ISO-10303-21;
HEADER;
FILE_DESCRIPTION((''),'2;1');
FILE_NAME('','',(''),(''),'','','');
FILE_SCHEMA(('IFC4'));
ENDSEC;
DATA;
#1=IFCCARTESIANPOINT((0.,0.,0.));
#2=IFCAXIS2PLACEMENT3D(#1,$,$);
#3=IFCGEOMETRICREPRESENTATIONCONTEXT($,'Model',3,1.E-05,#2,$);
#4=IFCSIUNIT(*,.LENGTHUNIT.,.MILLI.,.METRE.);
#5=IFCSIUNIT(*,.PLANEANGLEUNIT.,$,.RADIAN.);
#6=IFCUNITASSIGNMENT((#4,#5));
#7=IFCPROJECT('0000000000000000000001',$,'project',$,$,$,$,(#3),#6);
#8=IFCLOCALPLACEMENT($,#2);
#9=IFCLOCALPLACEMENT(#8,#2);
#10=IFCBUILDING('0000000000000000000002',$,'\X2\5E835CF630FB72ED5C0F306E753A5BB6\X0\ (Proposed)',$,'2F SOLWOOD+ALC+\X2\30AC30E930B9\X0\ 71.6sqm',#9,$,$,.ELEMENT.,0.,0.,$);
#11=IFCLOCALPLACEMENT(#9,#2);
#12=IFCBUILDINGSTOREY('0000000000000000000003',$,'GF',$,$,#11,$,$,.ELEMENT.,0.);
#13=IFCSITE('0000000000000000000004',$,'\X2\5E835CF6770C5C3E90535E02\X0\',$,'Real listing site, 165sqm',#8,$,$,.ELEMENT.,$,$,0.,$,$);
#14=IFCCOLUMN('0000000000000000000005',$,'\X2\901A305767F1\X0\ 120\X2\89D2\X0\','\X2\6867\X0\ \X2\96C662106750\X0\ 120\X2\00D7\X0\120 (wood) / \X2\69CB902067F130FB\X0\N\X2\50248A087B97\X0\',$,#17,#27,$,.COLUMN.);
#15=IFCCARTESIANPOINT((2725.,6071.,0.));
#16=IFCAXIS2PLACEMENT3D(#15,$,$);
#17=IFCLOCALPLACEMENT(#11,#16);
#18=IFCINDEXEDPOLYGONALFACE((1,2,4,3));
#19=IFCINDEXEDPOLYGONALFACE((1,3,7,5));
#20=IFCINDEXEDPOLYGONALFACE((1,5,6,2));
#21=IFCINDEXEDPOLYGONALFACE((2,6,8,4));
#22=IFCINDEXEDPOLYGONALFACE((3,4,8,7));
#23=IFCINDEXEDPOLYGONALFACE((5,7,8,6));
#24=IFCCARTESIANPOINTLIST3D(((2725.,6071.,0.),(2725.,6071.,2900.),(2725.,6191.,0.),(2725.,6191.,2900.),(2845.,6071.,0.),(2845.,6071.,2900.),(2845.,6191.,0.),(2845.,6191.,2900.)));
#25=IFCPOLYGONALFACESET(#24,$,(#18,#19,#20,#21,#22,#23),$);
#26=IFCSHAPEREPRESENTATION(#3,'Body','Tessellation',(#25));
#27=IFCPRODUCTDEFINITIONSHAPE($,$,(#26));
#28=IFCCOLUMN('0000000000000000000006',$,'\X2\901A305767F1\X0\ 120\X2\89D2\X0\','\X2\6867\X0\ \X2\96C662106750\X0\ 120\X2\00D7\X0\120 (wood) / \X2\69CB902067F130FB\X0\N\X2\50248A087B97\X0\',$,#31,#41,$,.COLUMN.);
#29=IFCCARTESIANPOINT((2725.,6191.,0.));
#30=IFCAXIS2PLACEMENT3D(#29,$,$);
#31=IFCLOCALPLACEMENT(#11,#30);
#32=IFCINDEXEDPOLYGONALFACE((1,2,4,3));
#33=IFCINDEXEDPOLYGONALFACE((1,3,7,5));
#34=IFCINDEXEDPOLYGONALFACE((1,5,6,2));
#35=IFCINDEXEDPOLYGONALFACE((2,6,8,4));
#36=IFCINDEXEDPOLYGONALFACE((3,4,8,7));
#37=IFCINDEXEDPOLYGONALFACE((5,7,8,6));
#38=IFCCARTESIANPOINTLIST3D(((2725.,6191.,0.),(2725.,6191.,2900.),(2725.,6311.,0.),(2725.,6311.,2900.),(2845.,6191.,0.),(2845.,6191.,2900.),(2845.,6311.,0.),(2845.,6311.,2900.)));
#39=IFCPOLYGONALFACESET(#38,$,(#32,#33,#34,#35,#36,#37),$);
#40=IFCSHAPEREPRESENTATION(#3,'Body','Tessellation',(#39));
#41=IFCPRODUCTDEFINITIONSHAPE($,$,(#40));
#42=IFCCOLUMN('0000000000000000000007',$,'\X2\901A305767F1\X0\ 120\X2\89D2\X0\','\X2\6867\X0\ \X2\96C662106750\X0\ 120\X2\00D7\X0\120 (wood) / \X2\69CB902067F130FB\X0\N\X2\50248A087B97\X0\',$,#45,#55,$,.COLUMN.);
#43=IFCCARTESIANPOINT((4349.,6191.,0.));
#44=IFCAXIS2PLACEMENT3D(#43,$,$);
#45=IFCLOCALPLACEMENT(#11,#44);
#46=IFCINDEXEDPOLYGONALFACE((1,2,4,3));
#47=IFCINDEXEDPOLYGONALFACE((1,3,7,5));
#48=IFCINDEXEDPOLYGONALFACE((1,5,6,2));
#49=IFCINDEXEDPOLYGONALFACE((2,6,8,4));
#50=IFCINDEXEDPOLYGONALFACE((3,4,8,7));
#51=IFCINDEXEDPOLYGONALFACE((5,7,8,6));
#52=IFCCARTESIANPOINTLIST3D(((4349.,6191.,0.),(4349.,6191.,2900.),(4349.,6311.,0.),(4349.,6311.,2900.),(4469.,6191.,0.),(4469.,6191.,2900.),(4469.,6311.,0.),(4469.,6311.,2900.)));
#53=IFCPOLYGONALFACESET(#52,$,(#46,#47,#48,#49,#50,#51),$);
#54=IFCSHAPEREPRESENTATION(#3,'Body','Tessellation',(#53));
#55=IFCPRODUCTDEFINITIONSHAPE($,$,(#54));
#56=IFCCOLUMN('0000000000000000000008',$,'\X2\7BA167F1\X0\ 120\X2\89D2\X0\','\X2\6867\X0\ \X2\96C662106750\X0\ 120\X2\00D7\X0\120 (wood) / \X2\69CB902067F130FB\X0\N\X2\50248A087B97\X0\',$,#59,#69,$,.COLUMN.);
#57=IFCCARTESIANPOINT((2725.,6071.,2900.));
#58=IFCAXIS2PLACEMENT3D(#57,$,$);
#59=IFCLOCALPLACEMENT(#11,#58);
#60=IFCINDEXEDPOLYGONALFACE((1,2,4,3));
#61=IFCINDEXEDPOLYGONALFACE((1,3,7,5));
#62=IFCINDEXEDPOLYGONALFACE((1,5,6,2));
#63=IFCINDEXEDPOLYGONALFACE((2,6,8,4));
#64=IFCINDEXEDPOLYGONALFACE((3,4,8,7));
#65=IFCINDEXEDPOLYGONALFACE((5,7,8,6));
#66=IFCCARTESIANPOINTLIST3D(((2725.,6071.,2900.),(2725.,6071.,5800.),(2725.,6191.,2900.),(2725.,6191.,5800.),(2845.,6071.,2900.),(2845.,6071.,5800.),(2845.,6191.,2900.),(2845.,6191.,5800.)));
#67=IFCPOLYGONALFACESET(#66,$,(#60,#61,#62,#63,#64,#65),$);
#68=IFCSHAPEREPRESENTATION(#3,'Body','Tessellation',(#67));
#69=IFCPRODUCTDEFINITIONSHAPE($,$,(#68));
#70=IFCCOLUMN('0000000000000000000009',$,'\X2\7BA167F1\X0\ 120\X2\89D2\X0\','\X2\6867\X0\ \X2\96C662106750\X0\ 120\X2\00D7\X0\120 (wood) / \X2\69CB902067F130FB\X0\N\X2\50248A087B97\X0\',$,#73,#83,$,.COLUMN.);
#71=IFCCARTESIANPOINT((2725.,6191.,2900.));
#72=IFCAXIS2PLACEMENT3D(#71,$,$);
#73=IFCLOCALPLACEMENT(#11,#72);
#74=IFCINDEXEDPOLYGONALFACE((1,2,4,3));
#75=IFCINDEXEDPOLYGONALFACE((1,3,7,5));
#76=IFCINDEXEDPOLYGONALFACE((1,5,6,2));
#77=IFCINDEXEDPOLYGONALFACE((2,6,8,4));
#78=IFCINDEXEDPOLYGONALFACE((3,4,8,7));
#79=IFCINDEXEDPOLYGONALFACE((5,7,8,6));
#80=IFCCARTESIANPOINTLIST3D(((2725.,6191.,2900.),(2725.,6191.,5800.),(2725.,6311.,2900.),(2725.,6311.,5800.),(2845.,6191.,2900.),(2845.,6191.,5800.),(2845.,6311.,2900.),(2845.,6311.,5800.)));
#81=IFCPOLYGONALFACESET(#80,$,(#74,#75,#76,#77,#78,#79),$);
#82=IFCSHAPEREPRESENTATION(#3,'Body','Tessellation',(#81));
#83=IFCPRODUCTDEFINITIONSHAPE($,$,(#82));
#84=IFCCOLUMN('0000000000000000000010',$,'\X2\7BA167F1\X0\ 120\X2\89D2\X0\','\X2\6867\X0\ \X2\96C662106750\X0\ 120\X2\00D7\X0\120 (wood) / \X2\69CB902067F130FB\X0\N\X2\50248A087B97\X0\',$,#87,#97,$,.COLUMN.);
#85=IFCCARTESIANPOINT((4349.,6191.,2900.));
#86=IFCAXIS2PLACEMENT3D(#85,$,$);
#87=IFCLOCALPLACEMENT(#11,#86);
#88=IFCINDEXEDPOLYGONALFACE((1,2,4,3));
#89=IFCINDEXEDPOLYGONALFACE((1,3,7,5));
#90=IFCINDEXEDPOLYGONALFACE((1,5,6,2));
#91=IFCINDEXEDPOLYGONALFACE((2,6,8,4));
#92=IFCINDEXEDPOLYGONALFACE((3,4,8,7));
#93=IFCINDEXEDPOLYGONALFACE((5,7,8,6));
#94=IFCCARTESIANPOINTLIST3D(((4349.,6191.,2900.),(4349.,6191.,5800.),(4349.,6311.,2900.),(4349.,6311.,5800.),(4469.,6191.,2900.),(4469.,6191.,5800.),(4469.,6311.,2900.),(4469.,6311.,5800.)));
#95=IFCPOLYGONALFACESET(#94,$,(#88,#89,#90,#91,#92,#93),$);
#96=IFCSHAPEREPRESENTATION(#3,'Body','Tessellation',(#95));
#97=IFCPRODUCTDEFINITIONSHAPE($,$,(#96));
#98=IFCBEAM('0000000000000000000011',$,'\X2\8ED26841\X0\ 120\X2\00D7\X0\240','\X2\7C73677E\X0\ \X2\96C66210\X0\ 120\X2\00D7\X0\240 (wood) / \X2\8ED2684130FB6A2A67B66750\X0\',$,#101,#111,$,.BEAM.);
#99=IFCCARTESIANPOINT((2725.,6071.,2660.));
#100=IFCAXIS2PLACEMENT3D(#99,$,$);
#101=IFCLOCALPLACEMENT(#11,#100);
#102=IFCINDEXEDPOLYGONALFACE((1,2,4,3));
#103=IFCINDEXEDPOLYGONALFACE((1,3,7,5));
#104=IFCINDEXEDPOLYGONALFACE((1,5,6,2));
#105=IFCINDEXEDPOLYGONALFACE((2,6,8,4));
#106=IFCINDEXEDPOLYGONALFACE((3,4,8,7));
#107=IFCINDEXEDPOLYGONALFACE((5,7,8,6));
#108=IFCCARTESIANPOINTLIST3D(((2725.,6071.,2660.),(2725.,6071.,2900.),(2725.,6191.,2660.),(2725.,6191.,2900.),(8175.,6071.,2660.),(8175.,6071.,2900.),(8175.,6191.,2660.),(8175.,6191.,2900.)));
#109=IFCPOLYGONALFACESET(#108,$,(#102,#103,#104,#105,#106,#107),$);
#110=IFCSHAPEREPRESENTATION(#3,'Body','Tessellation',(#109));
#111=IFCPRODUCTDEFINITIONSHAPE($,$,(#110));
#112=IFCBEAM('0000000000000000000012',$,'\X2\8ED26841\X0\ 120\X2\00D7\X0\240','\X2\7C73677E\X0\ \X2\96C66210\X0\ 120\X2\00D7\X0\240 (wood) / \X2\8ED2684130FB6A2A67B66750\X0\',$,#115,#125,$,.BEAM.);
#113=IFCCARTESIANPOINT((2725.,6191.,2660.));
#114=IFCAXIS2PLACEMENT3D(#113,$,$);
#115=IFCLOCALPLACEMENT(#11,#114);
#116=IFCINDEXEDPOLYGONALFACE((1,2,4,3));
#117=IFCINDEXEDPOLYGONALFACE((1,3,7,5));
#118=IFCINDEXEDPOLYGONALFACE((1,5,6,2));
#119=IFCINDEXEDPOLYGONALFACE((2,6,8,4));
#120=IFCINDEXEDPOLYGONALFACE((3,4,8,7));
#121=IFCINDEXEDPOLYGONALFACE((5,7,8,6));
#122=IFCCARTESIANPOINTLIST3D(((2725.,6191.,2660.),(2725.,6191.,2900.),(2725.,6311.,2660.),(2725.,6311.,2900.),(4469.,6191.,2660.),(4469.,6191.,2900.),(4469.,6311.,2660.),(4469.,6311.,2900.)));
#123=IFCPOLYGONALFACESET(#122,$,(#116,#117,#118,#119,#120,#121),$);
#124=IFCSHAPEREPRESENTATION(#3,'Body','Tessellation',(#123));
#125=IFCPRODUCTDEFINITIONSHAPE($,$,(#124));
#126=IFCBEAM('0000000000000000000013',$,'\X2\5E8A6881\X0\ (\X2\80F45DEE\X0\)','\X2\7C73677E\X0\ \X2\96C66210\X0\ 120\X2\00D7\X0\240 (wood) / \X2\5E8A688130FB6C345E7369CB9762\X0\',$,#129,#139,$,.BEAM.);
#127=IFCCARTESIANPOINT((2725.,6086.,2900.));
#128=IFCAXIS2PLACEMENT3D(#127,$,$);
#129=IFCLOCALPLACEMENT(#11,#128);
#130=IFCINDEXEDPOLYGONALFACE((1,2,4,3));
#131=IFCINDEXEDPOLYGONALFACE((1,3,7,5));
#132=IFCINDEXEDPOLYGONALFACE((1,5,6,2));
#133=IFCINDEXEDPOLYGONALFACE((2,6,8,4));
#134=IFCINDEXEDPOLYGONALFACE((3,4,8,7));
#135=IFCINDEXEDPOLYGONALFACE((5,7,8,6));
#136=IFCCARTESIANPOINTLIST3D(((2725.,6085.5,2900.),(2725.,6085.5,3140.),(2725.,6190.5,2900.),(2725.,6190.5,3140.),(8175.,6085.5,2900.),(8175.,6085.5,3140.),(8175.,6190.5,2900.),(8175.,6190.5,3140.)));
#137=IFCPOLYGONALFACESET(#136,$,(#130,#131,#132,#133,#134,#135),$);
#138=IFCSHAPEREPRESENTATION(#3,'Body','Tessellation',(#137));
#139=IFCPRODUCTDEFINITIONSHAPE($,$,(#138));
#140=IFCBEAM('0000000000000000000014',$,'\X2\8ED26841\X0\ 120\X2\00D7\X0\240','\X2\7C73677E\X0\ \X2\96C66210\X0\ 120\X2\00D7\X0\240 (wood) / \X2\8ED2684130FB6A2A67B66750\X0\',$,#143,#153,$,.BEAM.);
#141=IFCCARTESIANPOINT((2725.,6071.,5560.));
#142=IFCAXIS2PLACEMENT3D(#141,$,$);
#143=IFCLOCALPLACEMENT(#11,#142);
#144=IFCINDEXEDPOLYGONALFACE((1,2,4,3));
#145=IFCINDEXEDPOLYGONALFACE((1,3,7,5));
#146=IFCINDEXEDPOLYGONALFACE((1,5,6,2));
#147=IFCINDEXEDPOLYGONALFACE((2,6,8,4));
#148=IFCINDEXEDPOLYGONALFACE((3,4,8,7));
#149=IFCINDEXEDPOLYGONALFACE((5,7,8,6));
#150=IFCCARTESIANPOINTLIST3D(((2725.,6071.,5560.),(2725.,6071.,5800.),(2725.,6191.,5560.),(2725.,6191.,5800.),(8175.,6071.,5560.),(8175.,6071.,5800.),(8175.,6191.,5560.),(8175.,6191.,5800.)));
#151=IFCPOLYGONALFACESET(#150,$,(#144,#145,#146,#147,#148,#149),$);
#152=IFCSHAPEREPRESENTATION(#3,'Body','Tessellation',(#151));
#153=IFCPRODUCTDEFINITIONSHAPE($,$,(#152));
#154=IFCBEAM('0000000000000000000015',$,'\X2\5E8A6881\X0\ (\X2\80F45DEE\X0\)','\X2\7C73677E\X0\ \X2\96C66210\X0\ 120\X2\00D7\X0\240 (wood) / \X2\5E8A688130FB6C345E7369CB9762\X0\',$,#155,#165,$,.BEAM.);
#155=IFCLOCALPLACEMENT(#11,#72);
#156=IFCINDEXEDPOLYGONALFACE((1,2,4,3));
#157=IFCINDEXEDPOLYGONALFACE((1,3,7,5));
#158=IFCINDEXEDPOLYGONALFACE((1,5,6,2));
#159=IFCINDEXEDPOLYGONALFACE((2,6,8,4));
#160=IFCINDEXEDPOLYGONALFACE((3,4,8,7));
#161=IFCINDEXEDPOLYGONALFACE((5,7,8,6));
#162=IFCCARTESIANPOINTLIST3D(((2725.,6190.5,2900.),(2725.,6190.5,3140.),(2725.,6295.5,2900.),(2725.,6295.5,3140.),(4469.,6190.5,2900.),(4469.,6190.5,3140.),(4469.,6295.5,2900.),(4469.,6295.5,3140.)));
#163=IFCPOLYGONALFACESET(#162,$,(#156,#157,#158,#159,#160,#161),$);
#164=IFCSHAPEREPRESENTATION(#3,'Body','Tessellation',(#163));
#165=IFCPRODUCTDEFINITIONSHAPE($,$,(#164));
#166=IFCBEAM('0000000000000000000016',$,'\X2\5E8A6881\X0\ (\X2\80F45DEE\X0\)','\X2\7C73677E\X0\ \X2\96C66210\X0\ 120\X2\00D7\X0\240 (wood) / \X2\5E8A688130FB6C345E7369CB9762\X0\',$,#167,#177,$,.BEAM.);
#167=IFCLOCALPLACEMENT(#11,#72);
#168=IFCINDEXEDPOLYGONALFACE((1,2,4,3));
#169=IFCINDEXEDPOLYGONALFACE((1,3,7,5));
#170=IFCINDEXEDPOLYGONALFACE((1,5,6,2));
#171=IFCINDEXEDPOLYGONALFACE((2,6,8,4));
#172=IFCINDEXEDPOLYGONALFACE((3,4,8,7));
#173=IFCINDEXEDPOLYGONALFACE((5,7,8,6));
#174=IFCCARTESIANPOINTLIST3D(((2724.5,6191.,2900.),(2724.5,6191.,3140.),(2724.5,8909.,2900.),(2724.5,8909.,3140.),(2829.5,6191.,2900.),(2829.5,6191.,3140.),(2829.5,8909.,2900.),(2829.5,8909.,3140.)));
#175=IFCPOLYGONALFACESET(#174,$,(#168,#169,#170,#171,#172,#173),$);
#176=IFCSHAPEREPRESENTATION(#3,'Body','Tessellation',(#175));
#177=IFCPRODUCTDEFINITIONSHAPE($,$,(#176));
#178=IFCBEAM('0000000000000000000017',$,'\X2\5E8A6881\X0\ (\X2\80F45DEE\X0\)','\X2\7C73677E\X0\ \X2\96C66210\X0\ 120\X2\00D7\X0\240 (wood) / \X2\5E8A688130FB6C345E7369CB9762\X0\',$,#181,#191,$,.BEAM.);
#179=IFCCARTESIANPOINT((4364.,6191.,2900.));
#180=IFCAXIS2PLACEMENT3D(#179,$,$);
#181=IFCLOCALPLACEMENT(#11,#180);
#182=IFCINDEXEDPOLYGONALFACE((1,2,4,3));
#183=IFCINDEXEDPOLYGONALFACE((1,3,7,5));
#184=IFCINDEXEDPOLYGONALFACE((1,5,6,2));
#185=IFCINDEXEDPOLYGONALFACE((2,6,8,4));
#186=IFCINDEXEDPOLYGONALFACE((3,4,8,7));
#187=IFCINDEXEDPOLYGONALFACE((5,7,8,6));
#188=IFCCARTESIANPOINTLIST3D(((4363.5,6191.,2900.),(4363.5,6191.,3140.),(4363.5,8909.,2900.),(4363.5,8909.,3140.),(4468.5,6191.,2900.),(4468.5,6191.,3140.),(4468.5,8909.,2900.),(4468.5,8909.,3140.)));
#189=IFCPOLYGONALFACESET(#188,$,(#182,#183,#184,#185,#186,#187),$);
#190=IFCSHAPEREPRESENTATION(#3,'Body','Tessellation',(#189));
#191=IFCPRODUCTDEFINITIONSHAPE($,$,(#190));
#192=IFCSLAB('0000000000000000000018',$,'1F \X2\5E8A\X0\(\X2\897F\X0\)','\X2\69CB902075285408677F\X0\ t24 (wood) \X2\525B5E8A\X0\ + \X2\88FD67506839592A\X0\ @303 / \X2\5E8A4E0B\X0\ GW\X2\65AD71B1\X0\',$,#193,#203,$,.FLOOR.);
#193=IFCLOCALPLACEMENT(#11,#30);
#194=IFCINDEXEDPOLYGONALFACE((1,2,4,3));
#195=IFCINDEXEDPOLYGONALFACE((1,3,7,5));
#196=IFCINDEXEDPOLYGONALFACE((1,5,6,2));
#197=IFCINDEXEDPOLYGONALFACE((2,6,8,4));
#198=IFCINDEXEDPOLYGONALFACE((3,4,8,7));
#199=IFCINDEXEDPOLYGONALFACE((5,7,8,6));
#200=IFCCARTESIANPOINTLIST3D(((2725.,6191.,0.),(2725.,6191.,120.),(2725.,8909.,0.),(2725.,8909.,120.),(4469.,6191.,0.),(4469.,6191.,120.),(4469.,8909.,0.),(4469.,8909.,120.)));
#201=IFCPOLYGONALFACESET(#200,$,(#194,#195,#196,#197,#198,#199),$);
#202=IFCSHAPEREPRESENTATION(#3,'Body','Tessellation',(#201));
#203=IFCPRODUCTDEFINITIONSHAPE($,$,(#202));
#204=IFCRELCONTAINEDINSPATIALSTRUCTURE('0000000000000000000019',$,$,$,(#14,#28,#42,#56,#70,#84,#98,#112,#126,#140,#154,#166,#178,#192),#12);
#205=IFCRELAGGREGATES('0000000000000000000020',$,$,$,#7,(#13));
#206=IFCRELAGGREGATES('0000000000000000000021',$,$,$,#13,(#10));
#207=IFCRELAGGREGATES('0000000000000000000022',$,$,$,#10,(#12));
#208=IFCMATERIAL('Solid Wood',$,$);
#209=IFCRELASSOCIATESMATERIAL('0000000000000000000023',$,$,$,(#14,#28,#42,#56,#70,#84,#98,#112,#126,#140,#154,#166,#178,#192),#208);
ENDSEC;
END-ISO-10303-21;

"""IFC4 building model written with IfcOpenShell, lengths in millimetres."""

from ifc_helpers import new_model, si_unit, frame, frame_2d, origin, place, context, project, spatial, rectangle, extrude, material, element, save


model = new_model("IFC4")

# Units and contexts
model_context = context("Model", 3, precision=1e-05, world=origin())
ifc_project = project(units=[si_unit("LENGTHUNIT", "METRE", prefix="MILLI"), si_unit("PLANEANGLEUNIT", "RADIAN")], contexts=[model_context])

# Site, building, storey
site_placement = place(None, origin())
site = spatial("IfcSite", under=ifc_project, at=site_placement, Name="広島県尾道市", ObjectType="Real listing site, 165sqm", CompositionType="ELEMENT", RefElevation=0.0)
building_placement = place(site_placement, origin())
building = spatial("IfcBuilding", under=site, at=building_placement, Name="広島・狭小の町家 (Proposed)", ObjectType="2F SOLWOOD+ALC+ガラス 71.6sqm", CompositionType="ELEMENT", ElevationOfRefHeight=0.0, ElevationOfTerrain=0.0)
storey_placement = place(building_placement, origin())
storey = spatial("IfcBuildingStorey", under=building, at=storey_placement, Name="GF", CompositionType="ELEMENT", Elevation=0.0)

# Columns
ifc_material_1 = material(Name="Solid Wood")
column_1_placement = place(storey_placement, frame((2725.0, 6071.0, 0.0)))
element("IfcColumn", 1, at=column_1_placement, inside=storey, material=ifc_material_1, Name="通し柱 120角", Description="桧 集成材 120×120 (wood) / 構造柱・N値計算", PredefinedType="COLUMN", context=model_context, shape_type="SweptSolid", body=[
    extrude(rectangle(XDim=120.0, YDim=120.0, at=frame_2d((60.0, 60.0))), frame((2725.0, 6071.0, 0.0)), (0.0, 0.0, 1.0), 2900.0),
])
column_2_placement = place(storey_placement, frame((2725.0, 6191.0, 0.0)))
element("IfcColumn", 2, at=column_2_placement, inside=storey, material=ifc_material_1, Name="通し柱 120角", Description="桧 集成材 120×120 (wood) / 構造柱・N値計算", PredefinedType="COLUMN", context=model_context, shape_type="SweptSolid", body=[
    extrude(rectangle(XDim=120.0, YDim=120.0, at=frame_2d((60.0, 60.0))), frame((2725.0, 6191.0, 0.0)), (0.0, 0.0, 1.0), 2900.0),
])
column_3_placement = place(storey_placement, frame((4349.0, 6191.0, 0.0)))
element("IfcColumn", 3, at=column_3_placement, inside=storey, material=ifc_material_1, Name="通し柱 120角", Description="桧 集成材 120×120 (wood) / 構造柱・N値計算", PredefinedType="COLUMN", context=model_context, shape_type="SweptSolid", body=[
    extrude(rectangle(XDim=120.0, YDim=120.0, at=frame_2d((60.0, 60.0))), frame((4349.0, 6191.0, 0.0)), (0.0, 0.0, 1.0), 2900.0),
])
column_4_placement = place(storey_placement, frame((2725.0, 6071.0, 2900.0)))
element("IfcColumn", 4, at=column_4_placement, inside=storey, material=ifc_material_1, Name="管柱 120角", Description="桧 集成材 120×120 (wood) / 構造柱・N値計算", PredefinedType="COLUMN", context=model_context, shape_type="SweptSolid", body=[
    extrude(rectangle(XDim=120.0, YDim=120.0, at=frame_2d((60.0, 60.0))), frame((2725.0, 6071.0, 2900.0)), (0.0, 0.0, 1.0), 2900.0),
])
column_5_placement = place(storey_placement, frame((2725.0, 6191.0, 2900.0)))
element("IfcColumn", 5, at=column_5_placement, inside=storey, material=ifc_material_1, Name="管柱 120角", Description="桧 集成材 120×120 (wood) / 構造柱・N値計算", PredefinedType="COLUMN", context=model_context, shape_type="SweptSolid", body=[
    extrude(rectangle(XDim=120.0, YDim=120.0, at=frame_2d((60.0, 60.0))), frame((2725.0, 6191.0, 2900.0)), (0.0, 0.0, 1.0), 2900.0),
])
column_6_placement = place(storey_placement, frame((4349.0, 6191.0, 2900.0)))
element("IfcColumn", 6, at=column_6_placement, inside=storey, material=ifc_material_1, Name="管柱 120角", Description="桧 集成材 120×120 (wood) / 構造柱・N値計算", PredefinedType="COLUMN", context=model_context, shape_type="SweptSolid", body=[
    extrude(rectangle(XDim=120.0, YDim=120.0, at=frame_2d((60.0, 60.0))), frame((4349.0, 6191.0, 2900.0)), (0.0, 0.0, 1.0), 2900.0),
])

# Beams
beam_1_placement = place(storey_placement, frame((2725.0, 6071.0, 2660.0)))
element("IfcBeam", 7, at=beam_1_placement, inside=storey, material=ifc_material_1, Name="軒桁 120×240", Description="米松 集成 120×240 (wood) / 軒桁・横架材", PredefinedType="BEAM", context=model_context, shape_type="SweptSolid", body=[
    extrude(rectangle(XDim=5450.0, YDim=120.0, at=frame_2d((2725.0, 60.0))), frame((2725.0, 6071.0, 2660.0)), (0.0, 0.0, 1.0), 240.0),
])
beam_2_placement = place(storey_placement, frame((2725.0, 6191.0, 2660.0)))
element("IfcBeam", 8, at=beam_2_placement, inside=storey, material=ifc_material_1, Name="軒桁 120×240", Description="米松 集成 120×240 (wood) / 軒桁・横架材", PredefinedType="BEAM", context=model_context, shape_type="SweptSolid", body=[
    extrude(rectangle(XDim=1744.0, YDim=120.0, at=frame_2d((872.0, 60.0))), frame((2725.0, 6191.0, 2660.0)), (0.0, 0.0, 1.0), 240.0),
])
beam_3_placement = place(storey_placement, frame((2725.0, 6086.0, 2900.0)))
element("IfcBeam", 9, at=beam_3_placement, inside=storey, material=ifc_material_1, Name="床梁 (胴差)", Description="米松 集成 120×240 (wood) / 床梁・水平構面", PredefinedType="BEAM", context=model_context, shape_type="SweptSolid", body=[
    extrude(rectangle(XDim=5450.0, YDim=105.0, at=frame_2d((2725.0, 52.0))), frame((2725.0, 6086.0, 2900.0)), (0.0, 0.0, 1.0), 240.0),
])
beam_4_placement = place(storey_placement, frame((2725.0, 6071.0, 5560.0)))
element("IfcBeam", 10, at=beam_4_placement, inside=storey, material=ifc_material_1, Name="軒桁 120×240", Description="米松 集成 120×240 (wood) / 軒桁・横架材", PredefinedType="BEAM", context=model_context, shape_type="SweptSolid", body=[
    extrude(rectangle(XDim=5450.0, YDim=120.0, at=frame_2d((2725.0, 60.0))), frame((2725.0, 6071.0, 5560.0)), (0.0, 0.0, 1.0), 240.0),
])
beam_5_placement = place(storey_placement, frame((2725.0, 6191.0, 2900.0)))
element("IfcBeam", 11, at=beam_5_placement, inside=storey, material=ifc_material_1, Name="床梁 (胴差)", Description="米松 集成 120×240 (wood) / 床梁・水平構面", PredefinedType="BEAM", context=model_context, shape_type="SweptSolid", body=[
    extrude(rectangle(XDim=1744.0, YDim=105.0, at=frame_2d((872.0, 52.0))), frame((2725.0, 6191.0, 2900.0)), (0.0, 0.0, 1.0), 240.0),
])
beam_6_placement = place(storey_placement, frame((2725.0, 6191.0, 2900.0)))
element("IfcBeam", 12, at=beam_6_placement, inside=storey, material=ifc_material_1, Name="床梁 (胴差)", Description="米松 集成 120×240 (wood) / 床梁・水平構面", PredefinedType="BEAM", context=model_context, shape_type="SweptSolid", body=[
    extrude(rectangle(XDim=105.0, YDim=2718.0, at=frame_2d((52.0, 1359.0))), frame((2725.0, 6191.0, 2900.0)), (0.0, 0.0, 1.0), 240.0),
])
beam_7_placement = place(storey_placement, frame((4364.0, 6191.0, 2900.0)))
element("IfcBeam", 13, at=beam_7_placement, inside=storey, material=ifc_material_1, Name="床梁 (胴差)", Description="米松 集成 120×240 (wood) / 床梁・水平構面", PredefinedType="BEAM", context=model_context, shape_type="SweptSolid", body=[
    extrude(rectangle(XDim=105.0, YDim=2718.0, at=frame_2d((52.0, 1359.0))), frame((4364.0, 6191.0, 2900.0)), (0.0, 0.0, 1.0), 240.0),
])

# Slab
slab_1_placement = place(storey_placement, frame((2725.0, 6191.0, 0.0)))
element("IfcSlab", 14, at=slab_1_placement, inside=storey, material=ifc_material_1, Name="1F 床(西)", Description="構造用合板 t24 (wood) 剛床 + 製材根太 @303 / 床下 GW断熱", PredefinedType="FLOOR", context=model_context, shape_type="SweptSolid", body=[
    extrude(rectangle(XDim=1744.0, YDim=2718.0, at=frame_2d((872.0, 1359.0))), frame((2725.0, 6191.0, 0.0)), (0.0, 0.0, 1.0), 120.0),
])

save(model, "model.ifc")
